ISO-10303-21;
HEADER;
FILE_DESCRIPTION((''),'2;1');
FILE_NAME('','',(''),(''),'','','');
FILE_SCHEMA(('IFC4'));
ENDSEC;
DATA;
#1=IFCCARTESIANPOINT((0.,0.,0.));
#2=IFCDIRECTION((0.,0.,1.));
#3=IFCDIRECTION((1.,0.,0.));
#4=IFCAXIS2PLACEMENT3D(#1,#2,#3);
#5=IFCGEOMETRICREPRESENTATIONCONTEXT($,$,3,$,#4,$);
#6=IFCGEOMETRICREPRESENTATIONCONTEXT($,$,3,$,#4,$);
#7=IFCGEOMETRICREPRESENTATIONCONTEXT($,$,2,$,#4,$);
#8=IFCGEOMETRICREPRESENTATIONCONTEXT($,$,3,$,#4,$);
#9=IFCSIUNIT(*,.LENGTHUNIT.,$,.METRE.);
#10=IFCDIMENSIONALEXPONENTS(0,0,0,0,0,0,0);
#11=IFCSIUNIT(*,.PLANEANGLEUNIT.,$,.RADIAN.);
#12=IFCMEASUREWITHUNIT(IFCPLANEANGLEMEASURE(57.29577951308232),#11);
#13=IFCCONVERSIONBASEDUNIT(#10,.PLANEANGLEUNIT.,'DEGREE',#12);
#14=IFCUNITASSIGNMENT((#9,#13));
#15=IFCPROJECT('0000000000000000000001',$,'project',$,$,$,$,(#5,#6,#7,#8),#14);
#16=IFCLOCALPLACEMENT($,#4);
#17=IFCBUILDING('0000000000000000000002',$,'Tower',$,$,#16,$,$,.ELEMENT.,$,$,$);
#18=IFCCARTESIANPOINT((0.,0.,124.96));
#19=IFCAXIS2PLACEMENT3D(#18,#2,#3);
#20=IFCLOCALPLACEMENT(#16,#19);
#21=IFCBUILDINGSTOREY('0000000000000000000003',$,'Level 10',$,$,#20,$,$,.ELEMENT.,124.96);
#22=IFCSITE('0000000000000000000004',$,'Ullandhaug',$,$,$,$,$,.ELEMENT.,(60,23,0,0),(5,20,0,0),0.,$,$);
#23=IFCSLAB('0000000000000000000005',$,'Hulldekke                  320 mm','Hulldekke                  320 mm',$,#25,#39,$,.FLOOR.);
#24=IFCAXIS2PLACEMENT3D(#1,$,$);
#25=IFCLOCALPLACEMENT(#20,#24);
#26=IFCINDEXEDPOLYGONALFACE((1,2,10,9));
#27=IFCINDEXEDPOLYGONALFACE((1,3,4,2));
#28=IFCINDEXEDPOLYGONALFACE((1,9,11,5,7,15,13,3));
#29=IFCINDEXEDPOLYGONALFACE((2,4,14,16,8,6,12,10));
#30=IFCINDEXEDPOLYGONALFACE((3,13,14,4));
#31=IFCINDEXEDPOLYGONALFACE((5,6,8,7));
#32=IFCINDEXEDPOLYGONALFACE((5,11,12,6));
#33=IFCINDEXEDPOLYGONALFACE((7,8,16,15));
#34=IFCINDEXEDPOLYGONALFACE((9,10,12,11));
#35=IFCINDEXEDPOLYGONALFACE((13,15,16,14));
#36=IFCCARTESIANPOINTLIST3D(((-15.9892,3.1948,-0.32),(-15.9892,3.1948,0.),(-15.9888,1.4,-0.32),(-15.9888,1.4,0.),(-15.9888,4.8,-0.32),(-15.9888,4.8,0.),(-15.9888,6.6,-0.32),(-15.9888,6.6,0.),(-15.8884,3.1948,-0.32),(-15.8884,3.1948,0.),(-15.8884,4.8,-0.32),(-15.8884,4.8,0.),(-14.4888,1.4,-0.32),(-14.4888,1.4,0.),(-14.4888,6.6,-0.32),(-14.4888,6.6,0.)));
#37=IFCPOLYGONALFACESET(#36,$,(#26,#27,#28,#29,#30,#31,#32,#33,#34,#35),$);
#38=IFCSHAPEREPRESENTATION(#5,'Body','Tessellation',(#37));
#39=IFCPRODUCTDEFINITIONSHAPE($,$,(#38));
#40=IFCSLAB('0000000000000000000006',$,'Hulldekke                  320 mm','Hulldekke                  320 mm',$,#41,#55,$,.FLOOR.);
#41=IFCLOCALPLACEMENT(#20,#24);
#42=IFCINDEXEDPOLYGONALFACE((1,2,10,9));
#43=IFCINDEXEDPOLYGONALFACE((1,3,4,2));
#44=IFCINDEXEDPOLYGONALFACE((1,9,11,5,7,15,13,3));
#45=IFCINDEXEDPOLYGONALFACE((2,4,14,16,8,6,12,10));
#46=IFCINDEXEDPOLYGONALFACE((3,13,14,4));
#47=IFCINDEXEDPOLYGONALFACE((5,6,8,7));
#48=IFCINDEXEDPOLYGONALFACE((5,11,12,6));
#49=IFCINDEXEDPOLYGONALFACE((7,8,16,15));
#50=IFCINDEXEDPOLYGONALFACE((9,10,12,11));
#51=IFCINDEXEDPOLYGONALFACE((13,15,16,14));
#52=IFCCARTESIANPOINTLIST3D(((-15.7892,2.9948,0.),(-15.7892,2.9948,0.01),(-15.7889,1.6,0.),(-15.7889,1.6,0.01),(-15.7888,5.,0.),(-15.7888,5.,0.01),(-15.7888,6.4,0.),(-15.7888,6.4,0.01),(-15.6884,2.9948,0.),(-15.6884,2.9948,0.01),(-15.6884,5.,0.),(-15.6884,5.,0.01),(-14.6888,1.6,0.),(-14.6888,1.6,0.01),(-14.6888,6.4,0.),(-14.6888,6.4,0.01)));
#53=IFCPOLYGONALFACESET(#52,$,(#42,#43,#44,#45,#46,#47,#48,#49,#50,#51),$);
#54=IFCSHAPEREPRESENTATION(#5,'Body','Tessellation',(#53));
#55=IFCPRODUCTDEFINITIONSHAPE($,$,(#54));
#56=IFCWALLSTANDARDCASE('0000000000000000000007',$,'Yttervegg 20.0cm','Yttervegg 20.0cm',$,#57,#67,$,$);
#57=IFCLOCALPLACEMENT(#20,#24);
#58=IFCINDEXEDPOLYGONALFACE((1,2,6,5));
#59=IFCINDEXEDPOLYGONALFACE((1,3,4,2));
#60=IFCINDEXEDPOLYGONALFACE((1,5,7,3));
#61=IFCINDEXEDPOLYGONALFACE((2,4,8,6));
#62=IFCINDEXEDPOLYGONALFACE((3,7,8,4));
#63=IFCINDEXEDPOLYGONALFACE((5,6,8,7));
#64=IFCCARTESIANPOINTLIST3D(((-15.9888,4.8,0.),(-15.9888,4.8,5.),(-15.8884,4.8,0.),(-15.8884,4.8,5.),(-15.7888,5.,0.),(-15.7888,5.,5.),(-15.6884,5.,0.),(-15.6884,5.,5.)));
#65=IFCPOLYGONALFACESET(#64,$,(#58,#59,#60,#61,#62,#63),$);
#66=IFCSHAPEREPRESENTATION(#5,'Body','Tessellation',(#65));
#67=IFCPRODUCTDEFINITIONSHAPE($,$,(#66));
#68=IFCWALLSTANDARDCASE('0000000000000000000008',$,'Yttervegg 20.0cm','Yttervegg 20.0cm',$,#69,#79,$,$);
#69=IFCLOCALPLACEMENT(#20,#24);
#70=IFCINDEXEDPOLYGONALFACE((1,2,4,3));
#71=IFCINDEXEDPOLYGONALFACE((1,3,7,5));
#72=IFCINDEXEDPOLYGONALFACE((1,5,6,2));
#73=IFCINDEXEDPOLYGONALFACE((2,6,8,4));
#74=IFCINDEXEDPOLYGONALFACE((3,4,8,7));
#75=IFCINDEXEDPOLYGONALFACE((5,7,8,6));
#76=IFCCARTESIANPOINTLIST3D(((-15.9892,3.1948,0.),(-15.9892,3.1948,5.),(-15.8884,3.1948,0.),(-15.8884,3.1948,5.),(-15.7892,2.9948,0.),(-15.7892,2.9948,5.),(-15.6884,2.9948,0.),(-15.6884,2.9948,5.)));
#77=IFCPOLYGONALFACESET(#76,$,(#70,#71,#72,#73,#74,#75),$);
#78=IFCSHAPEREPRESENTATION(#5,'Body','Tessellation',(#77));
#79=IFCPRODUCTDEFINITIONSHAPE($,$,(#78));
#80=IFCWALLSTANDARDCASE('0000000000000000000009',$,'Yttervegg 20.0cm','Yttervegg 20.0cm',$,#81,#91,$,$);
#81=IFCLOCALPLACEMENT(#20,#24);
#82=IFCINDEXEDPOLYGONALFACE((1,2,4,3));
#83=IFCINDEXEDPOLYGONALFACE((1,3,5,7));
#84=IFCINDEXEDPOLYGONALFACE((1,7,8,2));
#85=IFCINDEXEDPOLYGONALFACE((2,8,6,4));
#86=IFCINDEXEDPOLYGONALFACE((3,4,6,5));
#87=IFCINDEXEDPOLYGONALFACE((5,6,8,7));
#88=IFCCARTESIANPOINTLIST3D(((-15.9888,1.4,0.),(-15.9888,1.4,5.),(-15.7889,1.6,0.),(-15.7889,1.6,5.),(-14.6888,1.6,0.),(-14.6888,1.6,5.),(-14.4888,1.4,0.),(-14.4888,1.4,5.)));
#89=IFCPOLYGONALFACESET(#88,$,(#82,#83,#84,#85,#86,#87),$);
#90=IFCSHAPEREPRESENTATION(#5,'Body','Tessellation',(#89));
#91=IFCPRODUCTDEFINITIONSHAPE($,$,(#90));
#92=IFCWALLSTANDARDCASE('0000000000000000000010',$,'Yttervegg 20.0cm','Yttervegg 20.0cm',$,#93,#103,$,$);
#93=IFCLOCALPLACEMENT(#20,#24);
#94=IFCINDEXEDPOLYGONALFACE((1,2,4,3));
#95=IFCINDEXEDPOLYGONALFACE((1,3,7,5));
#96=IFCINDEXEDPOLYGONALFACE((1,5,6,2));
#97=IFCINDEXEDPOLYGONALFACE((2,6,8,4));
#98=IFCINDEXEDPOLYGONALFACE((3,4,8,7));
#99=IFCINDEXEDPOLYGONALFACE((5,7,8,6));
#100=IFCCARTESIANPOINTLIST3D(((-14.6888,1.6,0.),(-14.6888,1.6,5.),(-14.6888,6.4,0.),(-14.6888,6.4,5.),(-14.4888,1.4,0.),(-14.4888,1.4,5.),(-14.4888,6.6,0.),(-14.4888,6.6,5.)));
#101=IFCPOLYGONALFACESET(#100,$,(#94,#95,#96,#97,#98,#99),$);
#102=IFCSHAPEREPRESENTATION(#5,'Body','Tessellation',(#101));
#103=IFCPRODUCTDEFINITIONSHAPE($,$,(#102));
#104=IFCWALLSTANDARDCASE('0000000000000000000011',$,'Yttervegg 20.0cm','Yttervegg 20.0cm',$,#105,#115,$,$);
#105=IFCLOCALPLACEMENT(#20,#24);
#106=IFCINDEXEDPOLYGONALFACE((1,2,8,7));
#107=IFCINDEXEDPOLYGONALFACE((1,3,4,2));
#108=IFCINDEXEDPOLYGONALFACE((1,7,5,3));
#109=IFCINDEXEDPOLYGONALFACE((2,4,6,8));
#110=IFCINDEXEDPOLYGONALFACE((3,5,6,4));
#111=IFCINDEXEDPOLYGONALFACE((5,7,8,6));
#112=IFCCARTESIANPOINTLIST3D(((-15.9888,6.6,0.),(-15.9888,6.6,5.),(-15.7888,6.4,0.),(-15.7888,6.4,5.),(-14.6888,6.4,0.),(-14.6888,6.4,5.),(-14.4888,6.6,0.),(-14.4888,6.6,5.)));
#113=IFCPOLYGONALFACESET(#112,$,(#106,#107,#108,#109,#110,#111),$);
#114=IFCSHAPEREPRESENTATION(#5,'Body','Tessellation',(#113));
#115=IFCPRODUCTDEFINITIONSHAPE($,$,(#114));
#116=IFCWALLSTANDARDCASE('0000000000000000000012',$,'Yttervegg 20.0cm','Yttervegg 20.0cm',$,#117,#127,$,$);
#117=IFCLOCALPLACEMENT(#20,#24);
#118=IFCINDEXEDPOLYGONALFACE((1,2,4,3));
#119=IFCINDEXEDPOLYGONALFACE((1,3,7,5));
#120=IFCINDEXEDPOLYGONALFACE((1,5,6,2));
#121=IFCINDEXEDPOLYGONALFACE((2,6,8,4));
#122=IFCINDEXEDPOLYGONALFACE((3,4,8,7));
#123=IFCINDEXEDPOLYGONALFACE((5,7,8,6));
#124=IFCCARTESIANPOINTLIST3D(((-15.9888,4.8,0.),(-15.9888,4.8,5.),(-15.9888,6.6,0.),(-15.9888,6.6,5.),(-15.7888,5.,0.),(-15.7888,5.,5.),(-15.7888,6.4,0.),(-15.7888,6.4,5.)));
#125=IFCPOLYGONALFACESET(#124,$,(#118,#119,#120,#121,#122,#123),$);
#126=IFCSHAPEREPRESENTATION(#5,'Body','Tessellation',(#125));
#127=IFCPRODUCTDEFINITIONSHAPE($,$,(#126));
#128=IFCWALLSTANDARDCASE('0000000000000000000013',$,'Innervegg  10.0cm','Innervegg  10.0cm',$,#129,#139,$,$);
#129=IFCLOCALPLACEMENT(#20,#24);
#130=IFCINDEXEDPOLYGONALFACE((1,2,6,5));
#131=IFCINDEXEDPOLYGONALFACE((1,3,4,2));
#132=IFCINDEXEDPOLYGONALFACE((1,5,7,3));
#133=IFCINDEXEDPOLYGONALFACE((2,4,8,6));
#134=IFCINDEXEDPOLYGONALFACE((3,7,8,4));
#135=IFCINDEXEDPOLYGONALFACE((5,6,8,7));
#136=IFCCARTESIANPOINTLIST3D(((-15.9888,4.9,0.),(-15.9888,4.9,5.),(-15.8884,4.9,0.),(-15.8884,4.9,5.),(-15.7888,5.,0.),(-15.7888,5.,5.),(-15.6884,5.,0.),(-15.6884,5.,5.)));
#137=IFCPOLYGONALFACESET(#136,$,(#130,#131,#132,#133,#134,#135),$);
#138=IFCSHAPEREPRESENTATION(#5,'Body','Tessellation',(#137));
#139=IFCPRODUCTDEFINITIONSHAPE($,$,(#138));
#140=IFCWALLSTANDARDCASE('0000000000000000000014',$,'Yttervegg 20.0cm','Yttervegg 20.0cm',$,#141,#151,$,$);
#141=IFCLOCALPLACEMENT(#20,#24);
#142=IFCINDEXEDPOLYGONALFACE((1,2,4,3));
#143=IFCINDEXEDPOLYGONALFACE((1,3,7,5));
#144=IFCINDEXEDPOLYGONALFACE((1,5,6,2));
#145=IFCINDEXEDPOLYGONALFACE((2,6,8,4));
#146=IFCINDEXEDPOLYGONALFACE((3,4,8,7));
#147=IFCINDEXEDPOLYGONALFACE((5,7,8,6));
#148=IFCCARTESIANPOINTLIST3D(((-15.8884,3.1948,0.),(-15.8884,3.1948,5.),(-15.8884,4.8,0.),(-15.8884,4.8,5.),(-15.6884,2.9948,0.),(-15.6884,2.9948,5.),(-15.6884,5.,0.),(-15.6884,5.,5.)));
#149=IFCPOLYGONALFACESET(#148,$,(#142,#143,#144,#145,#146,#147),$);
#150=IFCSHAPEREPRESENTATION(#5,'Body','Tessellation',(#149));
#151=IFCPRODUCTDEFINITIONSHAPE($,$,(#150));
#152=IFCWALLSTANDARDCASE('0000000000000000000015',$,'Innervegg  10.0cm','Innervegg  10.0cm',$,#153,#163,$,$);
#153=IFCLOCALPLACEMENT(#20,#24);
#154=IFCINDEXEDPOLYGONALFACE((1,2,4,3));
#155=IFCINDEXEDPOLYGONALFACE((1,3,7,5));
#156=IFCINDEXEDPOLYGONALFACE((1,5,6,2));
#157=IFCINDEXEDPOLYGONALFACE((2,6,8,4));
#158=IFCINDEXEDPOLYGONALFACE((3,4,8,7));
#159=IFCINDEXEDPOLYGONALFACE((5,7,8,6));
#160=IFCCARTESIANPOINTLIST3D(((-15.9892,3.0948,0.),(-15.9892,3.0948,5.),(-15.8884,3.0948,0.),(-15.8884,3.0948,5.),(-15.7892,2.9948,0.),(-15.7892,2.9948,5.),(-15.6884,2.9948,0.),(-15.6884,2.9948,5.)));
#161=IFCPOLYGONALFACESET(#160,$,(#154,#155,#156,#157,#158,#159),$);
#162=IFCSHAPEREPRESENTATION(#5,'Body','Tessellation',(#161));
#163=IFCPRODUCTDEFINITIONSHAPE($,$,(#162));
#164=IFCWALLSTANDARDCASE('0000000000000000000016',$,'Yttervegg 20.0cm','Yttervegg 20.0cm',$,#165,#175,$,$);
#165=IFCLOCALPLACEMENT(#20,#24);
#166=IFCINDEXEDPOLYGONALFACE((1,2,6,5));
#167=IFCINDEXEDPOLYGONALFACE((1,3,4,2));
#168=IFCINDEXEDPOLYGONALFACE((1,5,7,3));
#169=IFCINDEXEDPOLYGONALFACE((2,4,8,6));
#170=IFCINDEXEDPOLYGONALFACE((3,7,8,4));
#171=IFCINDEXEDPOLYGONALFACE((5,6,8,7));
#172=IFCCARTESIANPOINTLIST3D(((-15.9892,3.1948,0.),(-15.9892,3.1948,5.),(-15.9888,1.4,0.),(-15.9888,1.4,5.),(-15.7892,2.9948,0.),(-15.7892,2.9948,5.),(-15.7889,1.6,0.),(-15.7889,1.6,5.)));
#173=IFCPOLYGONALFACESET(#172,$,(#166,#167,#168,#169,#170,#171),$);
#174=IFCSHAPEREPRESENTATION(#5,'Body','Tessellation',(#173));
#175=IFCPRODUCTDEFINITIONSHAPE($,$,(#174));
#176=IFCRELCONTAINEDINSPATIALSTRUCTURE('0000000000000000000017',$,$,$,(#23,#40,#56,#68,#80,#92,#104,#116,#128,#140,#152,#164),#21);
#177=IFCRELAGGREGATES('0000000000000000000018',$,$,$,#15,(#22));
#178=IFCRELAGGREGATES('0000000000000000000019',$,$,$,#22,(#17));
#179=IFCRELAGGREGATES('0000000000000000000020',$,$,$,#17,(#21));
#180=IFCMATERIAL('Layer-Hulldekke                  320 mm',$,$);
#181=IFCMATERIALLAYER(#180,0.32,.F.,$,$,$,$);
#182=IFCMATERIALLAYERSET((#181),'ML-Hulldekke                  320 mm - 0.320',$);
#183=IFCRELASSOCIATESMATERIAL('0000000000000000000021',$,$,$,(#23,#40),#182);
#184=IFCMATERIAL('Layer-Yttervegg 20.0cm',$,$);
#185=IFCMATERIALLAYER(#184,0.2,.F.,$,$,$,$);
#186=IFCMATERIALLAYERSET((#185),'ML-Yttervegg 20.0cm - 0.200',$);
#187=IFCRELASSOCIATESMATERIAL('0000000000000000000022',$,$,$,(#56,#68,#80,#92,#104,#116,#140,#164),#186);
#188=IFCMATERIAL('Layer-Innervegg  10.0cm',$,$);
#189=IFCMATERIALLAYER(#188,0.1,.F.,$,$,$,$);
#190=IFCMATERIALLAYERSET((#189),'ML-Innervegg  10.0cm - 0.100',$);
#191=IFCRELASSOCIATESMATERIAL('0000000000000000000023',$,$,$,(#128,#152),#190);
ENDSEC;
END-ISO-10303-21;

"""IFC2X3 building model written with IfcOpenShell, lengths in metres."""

from ifc_helpers import new_model, entity, si_unit, converted_unit, frame, origin_with_axes, place, context, project, spatial, polyline, outline, extrude, material, layer, layer_set, layer_usage, element, save


model = new_model("IFC2X3")

# Units and contexts
context_of_model_1 = context(None, 3, world=origin_with_axes())
context_of_model_2 = context(None, 3, world=origin_with_axes())
context_of_model_3 = context(None, 2, world=origin_with_axes())
context_of_model_4 = context(None, 3, world=origin_with_axes())
ifc_project = project(units=[si_unit("LENGTHUNIT", "METRE"), converted_unit("PLANEANGLEUNIT", "DEGREE", entity("IfcPlaneAngleMeasure", 57.29577951308232), si_unit("PLANEANGLEUNIT", "RADIAN"), dimensions=[0, 0, 0, 0, 0, 0, 0])], contexts=[context_of_model_1, context_of_model_2, context_of_model_3, context_of_model_4])

# Site, building, storey
site = spatial("IfcSite", under=ifc_project, Name="Ullandhaug", CompositionType="ELEMENT", RefLatitude=(60, 23, 0, 0), RefLongitude=(5, 20, 0, 0), RefElevation=0.0)
building_placement = place(None, origin_with_axes())
building = spatial("IfcBuilding", under=site, at=building_placement, Name="Tower", CompositionType="ELEMENT")
storey_placement = place(building_placement, frame((0.0, 0.0, 124.96), z_axis=(0.0, 0.0, 1.0), x_axis=(1.0, 0.0, 0.0)))
storey = spatial("IfcBuildingStorey", under=building, at=storey_placement, Name="Level 10", CompositionType="ELEMENT", Elevation=124.96)

# Slabs
ifc_material_1 = material(Name="Layer-Hulldekke                  320 mm")
ifc_layer_1 = layer(ifc_material_1, 0.32, ventilated=False)
ifc_layer_set_1 = layer_set([ifc_layer_1], Name="ML-Hulldekke                  320 mm - 0.320")
ifc_layer_usage_1 = layer_usage(ifc_layer_set_1, "AXIS2", "POSITIVE", 0.0)
slab_1_placement = place(storey_placement, frame((-15.9888, 1.4, 0.0), z_axis=(0.0, 0.0, 1.0), x_axis=(1.0, 0.0, 0.0)))
element("IfcSlab", 1, at=slab_1_placement, inside=storey, material=ifc_layer_usage_1, Name="Hulldekke                  320 mm", Description="Hulldekke                  320 mm", PredefinedType="FLOOR", context=context_of_model_1, shape_type="SweptSolid", body=[
    extrude(outline(polyline([(0.0, 0.0), (1.5, 0.0), (1.5, 5.2), (0.0, 5.2), (0.0, 3.4), (0.1005, 3.4), (0.1005, 1.7948), (-0.0004, 1.7948), (0.0, 0.0)])), origin_with_axes(), (0.0, 0.0, -1.0), 0.32),
])
slab_2_placement = place(storey_placement, frame((-15.7889, 1.6, 0.0), z_axis=(0.0, 0.0, 1.0), x_axis=(1.0, 0.0, 0.0)))
element("IfcSlab", 2, at=slab_2_placement, inside=storey, material=ifc_layer_usage_1, Name="Hulldekke                  320 mm", Description="Hulldekke                  320 mm", PredefinedType="FLOOR", context=context_of_model_1, shape_type="SweptSolid", body=[
    extrude(outline(polyline([(0.0, 0.0), (1.1, 0.0), (1.1, 4.8), (0.0, 4.8), (0.0, 3.4), (0.1005, 3.4), (0.1005, 1.3948), (-0.0003, 1.3948), (0.0, 0.0)])), origin_with_axes(), (0.0, 0.0, 1.0), 0.01),
])

# Walls
ifc_material_2 = material(Name="Layer-Yttervegg 20.0cm")
ifc_layer_2 = layer(ifc_material_2, 0.2, ventilated=False)
ifc_layer_set_2 = layer_set([ifc_layer_2], Name="ML-Yttervegg 20.0cm - 0.200")
ifc_layer_usage_2 = layer_usage(ifc_layer_set_2, "AXIS2", "POSITIVE", 0.0)
wall_1_placement = place(storey_placement, frame((-15.9888, 4.8, 0.0), z_axis=(0.0, 0.0, 1.0), x_axis=(1.0, 0.0, 0.0)))
element("IfcWallStandardCase", 3, at=wall_1_placement, inside=storey, material=ifc_layer_usage_2, Name="Yttervegg 20.0cm", Description="Yttervegg 20.0cm", context=context_of_model_1, shape_type="SweptSolid", body=[
    extrude(outline(polyline([(0.0, 0.0), (0.1005, 0.0), (0.3005, 0.2), (0.2, 0.2), (0.0, 0.0)])), origin_with_axes(), (0.0, 0.0, 1.0), 5.0),
])
wall_2_placement = place(storey_placement, frame((-15.8884, 3.1948, 0.0), z_axis=(0.0, 0.0, 1.0), x_axis=(-1.0, 0.0, 0.0)))
element("IfcWallStandardCase", 4, at=wall_2_placement, inside=storey, material=ifc_layer_usage_2, Name="Yttervegg 20.0cm", Description="Yttervegg 20.0cm", context=context_of_model_1, shape_type="SweptSolid", body=[
    extrude(outline(polyline([(0.0, 0.0), (0.1009, 0.0), (-0.0992, 0.2), (-0.2, 0.2), (0.0, 0.0)])), frame((0.0, 0.0, 0.0), z_axis=(0.0, 0.0, 1.0), x_axis=(1.0, 0.0, 0.0)), (0.0, 0.0, 1.0), 5.0),
])
wall_3_placement = place(storey_placement, frame((-15.9888, 1.4, 0.0), z_axis=(0.0, 0.0, 1.0), x_axis=(1.0, 0.0, 0.0)))
element("IfcWallStandardCase", 5, at=wall_3_placement, inside=storey, material=ifc_layer_usage_2, Name="Yttervegg 20.0cm", Description="Yttervegg 20.0cm", context=context_of_model_1, shape_type="SweptSolid", body=[
    extrude(outline(polyline([(0.0, 0.0), (1.5, 0.0), (1.3, 0.2), (0.2, 0.2), (0.0, 0.0)])), origin_with_axes(), (0.0, 0.0, 1.0), 5.0),
])
wall_4_placement = place(storey_placement, frame((-14.4888, 1.4, 0.0), z_axis=(0.0, 0.0, 1.0), x_axis=(0.0, 1.0, 0.0)))
element("IfcWallStandardCase", 6, at=wall_4_placement, inside=storey, material=ifc_layer_usage_2, Name="Yttervegg 20.0cm", Description="Yttervegg 20.0cm", context=context_of_model_1, shape_type="SweptSolid", body=[
    extrude(outline(polyline([(0.0, 0.0), (5.2, 0.0), (5.0, 0.2), (0.2, 0.2), (0.0, 0.0)])), frame((0.0, 0.0, 0.0), z_axis=(0.0, 0.0, 1.0), x_axis=(1.0, 0.0, 0.0)), (0.0, 0.0, 1.0), 5.0),
])
wall_5_placement = place(storey_placement, frame((-14.4888, 6.6, 0.0), z_axis=(0.0, 0.0, 1.0), x_axis=(-1.0, 0.0, 0.0)))
element("IfcWallStandardCase", 7, at=wall_5_placement, inside=storey, material=ifc_layer_usage_2, Name="Yttervegg 20.0cm", Description="Yttervegg 20.0cm", context=context_of_model_1, shape_type="SweptSolid", body=[
    extrude(outline(polyline([(0.0, 0.0), (1.5, 0.0), (1.3, 0.2), (0.2, 0.2), (0.0, 0.0)])), frame((0.0, 0.0, 0.0), z_axis=(0.0, 0.0, 1.0), x_axis=(1.0, 0.0, 0.0)), (0.0, 0.0, 1.0), 5.0),
])
wall_6_placement = place(storey_placement, frame((-15.9888, 6.6, 0.0), z_axis=(0.0, 0.0, 1.0), x_axis=(0.0, -1.0, 0.0)))
element("IfcWallStandardCase", 8, at=wall_6_placement, inside=storey, material=ifc_layer_usage_2, Name="Yttervegg 20.0cm", Description="Yttervegg 20.0cm", context=context_of_model_1, shape_type="SweptSolid", body=[
    extrude(outline(polyline([(0.0, 0.0), (1.8, 0.0), (1.6, 0.2), (0.2, 0.2), (0.0, 0.0)])), frame((0.0, 0.0, 0.0), z_axis=(0.0, 0.0, 1.0), x_axis=(1.0, 0.0, 0.0)), (0.0, 0.0, 1.0), 5.0),
])
ifc_material_3 = material(Name="Layer-Innervegg  10.0cm")
ifc_layer_3 = layer(ifc_material_3, 0.1, ventilated=False)
ifc_layer_set_3 = layer_set([ifc_layer_3], Name="ML-Innervegg  10.0cm - 0.100")
ifc_layer_usage_3 = layer_usage(ifc_layer_set_3, "AXIS2", "POSITIVE", 0.0)
wall_7_placement = place(storey_placement, frame((-15.9888, 4.9, 0.0), z_axis=(0.0, 0.0, 1.0), x_axis=(1.0, 0.0, 0.0)))
element("IfcWallStandardCase", 9, at=wall_7_placement, inside=storey, material=ifc_layer_usage_3, Name="Innervegg  10.0cm", Description="Innervegg  10.0cm", context=context_of_model_1, shape_type="SweptSolid", body=[
    extrude(outline(polyline([(0.0, 0.0), (0.1005, 0.0), (0.3005, 0.1), (0.2, 0.1), (0.0, 0.0)])), origin_with_axes(), (0.0, 0.0, 1.0), 5.0),
])
wall_8_placement = place(storey_placement, frame((-15.8884, 4.8, 0.0), z_axis=(0.0, 0.0, 1.0), x_axis=(0.0, -1.0, 0.0)))
element("IfcWallStandardCase", 10, at=wall_8_placement, inside=storey, material=ifc_layer_usage_2, Name="Yttervegg 20.0cm", Description="Yttervegg 20.0cm", context=context_of_model_1, shape_type="SweptSolid", body=[
    extrude(outline(polyline([(0.0, 0.0), (1.6052, 0.0), (1.8052, 0.2), (-0.2, 0.2), (0.0, 0.0)])), frame((0.0, 0.0, 0.0), z_axis=(0.0, 0.0, 1.0), x_axis=(1.0, 0.0, 0.0)), (0.0, 0.0, 1.0), 5.0),
])
wall_9_placement = place(storey_placement, frame((-15.8884, 3.0948, 0.0), z_axis=(0.0, 0.0, 1.0), x_axis=(-1.0, 0.0, 0.0)))
element("IfcWallStandardCase", 11, at=wall_9_placement, inside=storey, material=ifc_layer_usage_3, Name="Innervegg  10.0cm", Description="Innervegg  10.0cm", context=context_of_model_1, shape_type="SweptSolid", body=[
    extrude(outline(polyline([(0.0, 0.0), (0.1009, 0.0), (-0.0992, 0.1), (-0.2, 0.1), (0.0, 0.0)])), frame((0.0, 0.0, 0.0), z_axis=(0.0, 0.0, 1.0), x_axis=(1.0, 0.0, 0.0)), (0.0, 0.0, 1.0), 5.0),
])
wall_10_placement = place(storey_placement, frame((-15.9892, 3.1948, 0.0), z_axis=(0.0, 0.0, 1.0), x_axis=(0.000225, -1.0, 0.0)))
element("IfcWallStandardCase", 12, at=wall_10_placement, inside=storey, material=ifc_layer_usage_2, Name="Yttervegg 20.0cm", Description="Yttervegg 20.0cm", context=context_of_model_1, shape_type="SweptSolid", body=[
    extrude(outline(polyline([(0.0, 0.0), (1.7948, 0.0), (1.5948, 0.2), (0.2, 0.2), (0.0, 0.0)])), frame((0.0, 0.0, 0.0), z_axis=(0.0, 0.0, 1.0), x_axis=(1.0, 0.0, 0.0)), (0.0, 0.0, 1.0), 5.0),
])

save(model, "model.ifc")
